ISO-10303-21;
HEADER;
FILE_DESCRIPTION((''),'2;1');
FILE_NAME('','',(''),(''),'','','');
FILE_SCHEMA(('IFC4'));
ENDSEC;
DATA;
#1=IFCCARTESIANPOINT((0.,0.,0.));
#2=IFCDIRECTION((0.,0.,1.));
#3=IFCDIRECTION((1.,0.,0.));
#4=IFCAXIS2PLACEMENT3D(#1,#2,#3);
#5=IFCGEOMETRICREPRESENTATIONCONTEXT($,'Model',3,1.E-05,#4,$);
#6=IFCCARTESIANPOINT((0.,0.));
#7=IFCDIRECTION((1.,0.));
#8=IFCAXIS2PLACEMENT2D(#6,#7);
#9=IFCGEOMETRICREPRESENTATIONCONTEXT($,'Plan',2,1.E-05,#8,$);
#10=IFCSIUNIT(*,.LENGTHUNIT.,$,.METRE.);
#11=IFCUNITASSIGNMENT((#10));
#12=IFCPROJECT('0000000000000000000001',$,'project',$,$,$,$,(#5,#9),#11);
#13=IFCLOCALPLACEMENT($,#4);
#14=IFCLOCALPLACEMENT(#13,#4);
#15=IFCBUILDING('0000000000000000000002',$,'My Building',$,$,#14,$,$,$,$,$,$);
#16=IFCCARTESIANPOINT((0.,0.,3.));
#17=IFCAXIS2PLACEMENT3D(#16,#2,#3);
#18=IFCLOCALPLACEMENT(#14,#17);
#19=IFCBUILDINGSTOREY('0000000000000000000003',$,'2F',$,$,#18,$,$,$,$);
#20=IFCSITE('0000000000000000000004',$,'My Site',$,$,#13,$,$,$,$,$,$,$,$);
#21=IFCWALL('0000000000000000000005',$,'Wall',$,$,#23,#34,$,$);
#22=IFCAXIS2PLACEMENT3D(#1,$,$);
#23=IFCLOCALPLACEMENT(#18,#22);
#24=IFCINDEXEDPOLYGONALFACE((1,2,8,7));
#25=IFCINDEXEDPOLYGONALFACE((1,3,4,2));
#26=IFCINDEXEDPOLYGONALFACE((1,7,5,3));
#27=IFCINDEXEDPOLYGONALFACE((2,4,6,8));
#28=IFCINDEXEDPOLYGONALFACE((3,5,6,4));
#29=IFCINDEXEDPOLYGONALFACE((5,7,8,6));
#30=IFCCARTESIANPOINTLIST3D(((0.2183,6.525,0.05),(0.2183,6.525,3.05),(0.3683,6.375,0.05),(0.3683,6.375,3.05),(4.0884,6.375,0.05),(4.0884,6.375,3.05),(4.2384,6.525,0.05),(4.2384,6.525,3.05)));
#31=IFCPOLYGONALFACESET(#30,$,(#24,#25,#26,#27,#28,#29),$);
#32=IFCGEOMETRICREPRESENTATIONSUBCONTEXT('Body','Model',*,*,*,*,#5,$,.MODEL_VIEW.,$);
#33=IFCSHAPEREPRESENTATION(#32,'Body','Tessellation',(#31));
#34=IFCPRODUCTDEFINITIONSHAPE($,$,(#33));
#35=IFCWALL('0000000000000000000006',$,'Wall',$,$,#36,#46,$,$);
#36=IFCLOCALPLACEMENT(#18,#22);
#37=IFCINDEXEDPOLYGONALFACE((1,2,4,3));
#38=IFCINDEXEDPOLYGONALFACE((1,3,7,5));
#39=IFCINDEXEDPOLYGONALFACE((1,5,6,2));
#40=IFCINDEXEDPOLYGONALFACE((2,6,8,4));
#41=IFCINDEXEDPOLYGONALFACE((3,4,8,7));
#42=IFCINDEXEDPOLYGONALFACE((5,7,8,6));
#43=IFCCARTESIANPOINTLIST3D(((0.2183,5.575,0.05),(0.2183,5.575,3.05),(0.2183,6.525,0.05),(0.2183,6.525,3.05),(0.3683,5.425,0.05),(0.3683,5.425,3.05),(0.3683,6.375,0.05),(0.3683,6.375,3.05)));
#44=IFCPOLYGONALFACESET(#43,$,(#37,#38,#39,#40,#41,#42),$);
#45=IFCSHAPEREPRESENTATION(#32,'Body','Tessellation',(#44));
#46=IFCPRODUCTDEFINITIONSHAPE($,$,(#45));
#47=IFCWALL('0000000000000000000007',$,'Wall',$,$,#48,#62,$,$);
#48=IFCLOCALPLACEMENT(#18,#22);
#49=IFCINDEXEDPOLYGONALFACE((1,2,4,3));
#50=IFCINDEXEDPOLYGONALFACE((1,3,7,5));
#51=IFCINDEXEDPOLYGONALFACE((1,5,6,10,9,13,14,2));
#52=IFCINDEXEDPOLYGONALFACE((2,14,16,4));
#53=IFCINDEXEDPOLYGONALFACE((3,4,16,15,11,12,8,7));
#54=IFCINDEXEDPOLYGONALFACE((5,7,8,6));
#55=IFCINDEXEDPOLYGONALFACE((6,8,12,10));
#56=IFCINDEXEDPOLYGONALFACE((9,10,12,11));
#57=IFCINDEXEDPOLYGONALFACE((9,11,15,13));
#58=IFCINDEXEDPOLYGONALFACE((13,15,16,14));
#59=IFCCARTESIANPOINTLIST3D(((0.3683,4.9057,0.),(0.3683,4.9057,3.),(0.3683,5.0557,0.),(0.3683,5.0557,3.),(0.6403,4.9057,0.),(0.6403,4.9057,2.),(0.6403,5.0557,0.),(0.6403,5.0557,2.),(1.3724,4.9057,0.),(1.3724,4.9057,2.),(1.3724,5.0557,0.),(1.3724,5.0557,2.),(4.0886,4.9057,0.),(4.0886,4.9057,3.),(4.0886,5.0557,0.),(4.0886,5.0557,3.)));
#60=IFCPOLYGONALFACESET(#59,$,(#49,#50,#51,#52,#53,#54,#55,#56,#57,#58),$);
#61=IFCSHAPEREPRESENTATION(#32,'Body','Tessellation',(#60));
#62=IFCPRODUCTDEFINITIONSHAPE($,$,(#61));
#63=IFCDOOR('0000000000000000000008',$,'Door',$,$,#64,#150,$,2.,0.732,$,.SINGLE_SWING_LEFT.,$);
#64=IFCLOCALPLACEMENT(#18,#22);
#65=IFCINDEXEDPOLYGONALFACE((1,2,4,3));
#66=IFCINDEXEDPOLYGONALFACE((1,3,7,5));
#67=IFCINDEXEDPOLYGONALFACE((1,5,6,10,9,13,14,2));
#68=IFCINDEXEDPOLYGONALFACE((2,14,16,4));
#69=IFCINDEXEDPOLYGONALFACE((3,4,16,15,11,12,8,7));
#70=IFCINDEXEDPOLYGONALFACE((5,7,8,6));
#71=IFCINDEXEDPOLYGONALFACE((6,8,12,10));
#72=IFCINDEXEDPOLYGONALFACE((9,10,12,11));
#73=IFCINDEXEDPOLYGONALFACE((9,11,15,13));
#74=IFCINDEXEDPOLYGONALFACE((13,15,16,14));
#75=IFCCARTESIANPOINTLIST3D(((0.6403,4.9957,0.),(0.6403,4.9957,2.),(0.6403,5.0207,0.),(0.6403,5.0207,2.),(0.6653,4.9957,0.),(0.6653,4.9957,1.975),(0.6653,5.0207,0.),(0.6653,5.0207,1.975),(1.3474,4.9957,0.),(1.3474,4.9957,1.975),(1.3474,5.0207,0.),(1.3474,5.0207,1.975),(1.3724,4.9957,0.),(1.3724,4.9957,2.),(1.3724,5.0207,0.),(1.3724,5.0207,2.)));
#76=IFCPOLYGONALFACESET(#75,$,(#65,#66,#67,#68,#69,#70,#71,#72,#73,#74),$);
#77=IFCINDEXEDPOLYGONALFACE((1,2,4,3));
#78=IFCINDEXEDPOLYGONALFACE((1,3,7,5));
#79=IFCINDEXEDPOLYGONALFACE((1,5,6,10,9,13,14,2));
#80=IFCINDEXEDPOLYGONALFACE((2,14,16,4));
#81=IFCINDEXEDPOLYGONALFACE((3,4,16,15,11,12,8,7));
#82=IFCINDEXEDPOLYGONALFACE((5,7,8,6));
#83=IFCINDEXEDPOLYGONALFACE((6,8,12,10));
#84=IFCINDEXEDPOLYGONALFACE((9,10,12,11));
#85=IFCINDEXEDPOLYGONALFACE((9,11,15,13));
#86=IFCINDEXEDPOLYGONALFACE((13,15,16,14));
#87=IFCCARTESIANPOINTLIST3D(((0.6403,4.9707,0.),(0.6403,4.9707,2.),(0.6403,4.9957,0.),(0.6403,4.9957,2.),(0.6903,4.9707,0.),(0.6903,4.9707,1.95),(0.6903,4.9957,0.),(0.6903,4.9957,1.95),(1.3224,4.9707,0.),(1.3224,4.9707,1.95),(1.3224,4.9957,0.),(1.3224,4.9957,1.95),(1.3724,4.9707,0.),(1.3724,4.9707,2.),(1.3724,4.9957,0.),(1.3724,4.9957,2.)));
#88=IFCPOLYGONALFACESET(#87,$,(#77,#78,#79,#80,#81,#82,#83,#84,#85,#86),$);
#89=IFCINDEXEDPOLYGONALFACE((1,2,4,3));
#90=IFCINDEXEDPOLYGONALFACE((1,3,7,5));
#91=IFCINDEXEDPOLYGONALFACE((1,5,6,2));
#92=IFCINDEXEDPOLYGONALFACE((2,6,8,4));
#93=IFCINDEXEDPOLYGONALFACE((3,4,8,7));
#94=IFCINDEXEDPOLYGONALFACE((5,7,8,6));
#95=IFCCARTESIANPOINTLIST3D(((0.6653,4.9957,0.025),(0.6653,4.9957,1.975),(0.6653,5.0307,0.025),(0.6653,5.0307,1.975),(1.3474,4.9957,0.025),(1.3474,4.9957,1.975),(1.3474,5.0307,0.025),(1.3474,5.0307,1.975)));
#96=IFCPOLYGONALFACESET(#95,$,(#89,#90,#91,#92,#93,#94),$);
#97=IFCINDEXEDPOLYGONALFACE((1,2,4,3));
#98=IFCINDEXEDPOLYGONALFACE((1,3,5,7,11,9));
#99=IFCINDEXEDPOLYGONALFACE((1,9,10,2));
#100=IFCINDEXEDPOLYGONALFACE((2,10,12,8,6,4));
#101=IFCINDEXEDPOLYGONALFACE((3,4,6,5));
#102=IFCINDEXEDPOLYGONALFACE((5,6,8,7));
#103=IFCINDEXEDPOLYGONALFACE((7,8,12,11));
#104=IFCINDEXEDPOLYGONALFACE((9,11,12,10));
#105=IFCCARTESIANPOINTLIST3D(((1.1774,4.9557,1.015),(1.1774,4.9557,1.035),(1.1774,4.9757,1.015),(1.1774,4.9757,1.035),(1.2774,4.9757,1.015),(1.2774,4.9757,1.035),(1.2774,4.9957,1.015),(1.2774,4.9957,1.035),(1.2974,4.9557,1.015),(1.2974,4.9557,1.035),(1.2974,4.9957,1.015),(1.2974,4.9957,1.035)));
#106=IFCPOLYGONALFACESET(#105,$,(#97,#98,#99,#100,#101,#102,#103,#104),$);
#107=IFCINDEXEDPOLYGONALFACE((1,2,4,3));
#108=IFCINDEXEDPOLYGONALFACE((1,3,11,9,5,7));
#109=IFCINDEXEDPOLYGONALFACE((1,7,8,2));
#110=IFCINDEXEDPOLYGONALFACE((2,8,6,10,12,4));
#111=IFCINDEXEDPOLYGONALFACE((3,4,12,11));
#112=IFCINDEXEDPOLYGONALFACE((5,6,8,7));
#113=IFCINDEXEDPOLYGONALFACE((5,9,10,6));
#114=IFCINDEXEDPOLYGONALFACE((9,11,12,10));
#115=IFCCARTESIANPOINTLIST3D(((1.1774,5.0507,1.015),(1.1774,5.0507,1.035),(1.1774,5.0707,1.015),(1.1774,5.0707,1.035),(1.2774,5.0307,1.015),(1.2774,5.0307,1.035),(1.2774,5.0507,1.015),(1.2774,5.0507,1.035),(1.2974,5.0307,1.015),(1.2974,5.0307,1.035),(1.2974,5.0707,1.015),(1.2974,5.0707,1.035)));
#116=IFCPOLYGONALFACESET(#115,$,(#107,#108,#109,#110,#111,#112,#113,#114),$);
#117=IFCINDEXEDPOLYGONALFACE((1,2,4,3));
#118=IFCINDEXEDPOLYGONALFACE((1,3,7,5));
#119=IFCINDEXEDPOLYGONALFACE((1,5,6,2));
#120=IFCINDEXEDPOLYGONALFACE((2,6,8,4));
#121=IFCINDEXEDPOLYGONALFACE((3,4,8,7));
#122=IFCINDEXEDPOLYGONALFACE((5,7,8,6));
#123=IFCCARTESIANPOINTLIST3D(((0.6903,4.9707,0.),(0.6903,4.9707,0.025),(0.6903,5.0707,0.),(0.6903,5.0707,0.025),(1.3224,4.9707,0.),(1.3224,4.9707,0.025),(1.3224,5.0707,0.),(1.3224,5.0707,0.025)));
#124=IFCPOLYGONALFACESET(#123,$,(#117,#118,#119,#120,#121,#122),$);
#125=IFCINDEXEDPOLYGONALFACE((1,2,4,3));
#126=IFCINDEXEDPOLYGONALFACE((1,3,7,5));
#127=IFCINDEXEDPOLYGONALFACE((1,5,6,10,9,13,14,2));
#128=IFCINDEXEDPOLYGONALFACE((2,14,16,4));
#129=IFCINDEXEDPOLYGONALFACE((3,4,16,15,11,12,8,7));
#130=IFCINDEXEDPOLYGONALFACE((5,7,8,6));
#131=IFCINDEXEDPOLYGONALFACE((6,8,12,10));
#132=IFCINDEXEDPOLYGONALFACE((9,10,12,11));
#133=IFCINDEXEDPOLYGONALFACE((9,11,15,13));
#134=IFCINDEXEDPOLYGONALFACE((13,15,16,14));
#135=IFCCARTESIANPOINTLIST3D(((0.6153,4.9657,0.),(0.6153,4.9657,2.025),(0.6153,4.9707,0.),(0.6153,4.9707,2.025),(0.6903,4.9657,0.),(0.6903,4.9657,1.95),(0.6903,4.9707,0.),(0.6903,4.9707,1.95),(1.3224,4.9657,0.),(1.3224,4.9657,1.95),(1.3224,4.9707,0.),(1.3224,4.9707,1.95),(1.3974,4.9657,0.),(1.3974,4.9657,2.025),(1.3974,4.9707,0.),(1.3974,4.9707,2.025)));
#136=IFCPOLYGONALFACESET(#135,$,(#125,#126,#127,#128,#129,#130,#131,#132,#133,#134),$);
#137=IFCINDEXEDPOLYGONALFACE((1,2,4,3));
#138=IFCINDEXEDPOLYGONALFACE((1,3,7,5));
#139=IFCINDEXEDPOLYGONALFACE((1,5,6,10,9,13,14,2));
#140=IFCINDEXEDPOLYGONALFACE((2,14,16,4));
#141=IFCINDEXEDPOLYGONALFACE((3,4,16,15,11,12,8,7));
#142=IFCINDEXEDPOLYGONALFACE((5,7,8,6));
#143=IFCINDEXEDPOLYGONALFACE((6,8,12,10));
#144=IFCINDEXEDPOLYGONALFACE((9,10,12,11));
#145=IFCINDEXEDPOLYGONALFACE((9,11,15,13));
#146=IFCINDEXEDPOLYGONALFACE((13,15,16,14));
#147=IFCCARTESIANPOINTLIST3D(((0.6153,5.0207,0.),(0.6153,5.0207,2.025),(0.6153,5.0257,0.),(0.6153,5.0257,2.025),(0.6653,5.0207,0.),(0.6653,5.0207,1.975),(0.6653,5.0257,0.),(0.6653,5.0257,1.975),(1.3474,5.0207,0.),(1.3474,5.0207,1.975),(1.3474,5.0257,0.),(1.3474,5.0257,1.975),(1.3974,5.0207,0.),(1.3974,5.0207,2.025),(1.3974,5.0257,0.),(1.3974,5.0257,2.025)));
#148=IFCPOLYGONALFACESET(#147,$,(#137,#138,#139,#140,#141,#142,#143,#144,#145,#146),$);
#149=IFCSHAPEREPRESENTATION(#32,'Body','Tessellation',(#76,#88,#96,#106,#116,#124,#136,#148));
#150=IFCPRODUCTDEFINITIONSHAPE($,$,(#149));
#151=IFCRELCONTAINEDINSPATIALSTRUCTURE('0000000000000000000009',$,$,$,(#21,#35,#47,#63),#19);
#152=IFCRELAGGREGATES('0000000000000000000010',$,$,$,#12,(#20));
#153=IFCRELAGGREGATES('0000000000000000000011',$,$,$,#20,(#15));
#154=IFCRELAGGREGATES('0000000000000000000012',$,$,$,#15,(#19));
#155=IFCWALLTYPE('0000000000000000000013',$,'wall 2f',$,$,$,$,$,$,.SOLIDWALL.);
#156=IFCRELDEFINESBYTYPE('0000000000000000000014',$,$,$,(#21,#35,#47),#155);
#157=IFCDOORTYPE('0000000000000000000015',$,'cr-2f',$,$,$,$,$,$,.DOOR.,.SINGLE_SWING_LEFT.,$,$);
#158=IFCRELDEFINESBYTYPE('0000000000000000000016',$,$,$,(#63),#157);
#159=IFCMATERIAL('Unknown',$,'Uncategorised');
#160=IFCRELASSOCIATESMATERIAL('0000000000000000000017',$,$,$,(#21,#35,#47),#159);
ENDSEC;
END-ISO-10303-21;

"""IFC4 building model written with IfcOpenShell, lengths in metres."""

from ifc_helpers import new_model, entity, si_unit, frame, origin_with_axes, origin_2d_with_axis, place, context, subcontext, project, spatial, line, indexed_curve, outline, extrude, shape, source, transform, mapped, material, type_object, type_shapes, element, fill, save


model = new_model("IFC4")

# Units and contexts
model_context = context("Model", 3, precision=1e-05, world=origin_with_axes())
plan_context = context("Plan", 2, precision=1e-05, world=origin_2d_with_axis())
body_context_1 = subcontext(model_context, "Body", "Model", "MODEL_VIEW")
body_context_2 = subcontext(plan_context, "Body", "Plan", "PLAN_VIEW")
ifc_project = project(units=[si_unit("LENGTHUNIT", "METRE")], contexts=[model_context, plan_context])

# Site, building, storey
site_placement = place(None, origin_with_axes())
site = spatial("IfcSite", under=ifc_project, at=site_placement, Name="My Site")
building_placement = place(site_placement, origin_with_axes())
building = spatial("IfcBuilding", under=site, at=building_placement, Name="My Building")
storey_placement = place(building_placement, frame((0.0, 0.0, 3.0), z_axis=(0.0, 0.0, 1.0), x_axis=(1.0, 0.0, 0.0)))
storey = spatial("IfcBuildingStorey", under=building, at=storey_placement, Name="2F")

# Shared definitions
ifc_material = material(Name="Unknown", Category="Uncategorised")

# Walls
wall_type_1 = type_object("IfcWallType", Name="wall 2f", PredefinedType="SOLIDWALL")
wall_1_placement = place(storey_placement, frame((4.2384, 6.525, 0.05), z_axis=(0.0, 0.0, 1.0), x_axis=(-1.0, 0.0, 0.0)))
element("IfcWall", 1, at=wall_1_placement, inside=storey, type_object=wall_type_1, material=ifc_material, Name="Wall", context=body_context_1, shape_type="SweptSolid", body=[
    extrude(outline(indexed_curve([(0.0, 0.0), (0.15, 0.15), (3.87, 0.15), (4.02, 0.0)], segments=[line(1, 2, 3, 4, 1)])), origin_with_axes(), (0.0, 0.0, 1.0), 3.0),
])
wall_2_placement = place(storey_placement, frame((0.2183, 6.525, 0.05), z_axis=(0.0, 0.0, 1.0), x_axis=(0.0, -1.0, 0.0)))
element("IfcWall", 2, at=wall_2_placement, inside=storey, type_object=wall_type_1, material=ifc_material, Name="Wall", context=body_context_1, shape_type="SweptSolid", body=[
    extrude(outline(indexed_curve([(0.0, 0.0), (0.15, 0.15), (1.1, 0.15), (0.95, 0.0)], segments=[line(1, 2, 3, 4, 1)])), origin_with_axes(), (0.0, 0.0, 1.0), 3.0),
])

# Wall, opening, door
wall_3_placement = place(storey_placement, frame((0.3683, 4.9057, 0.0), z_axis=(0.0, 0.0, 1.0), x_axis=(1.0, 0.0, 0.0)))
wall_3 = element("IfcWall", 3, at=wall_3_placement, inside=storey, type_object=wall_type_1, material=ifc_material, Name="Wall", context=body_context_1, shape_type="SweptSolid", body=[
    extrude(outline(indexed_curve([(0.0, 0.0), (0.0, 0.15), (3.7202, 0.15), (3.7202, 0.0)], segments=[line(1, 2, 3, 4, 1)])), origin_with_axes(), (0.0, 0.0, 1.0), 3.0),
])
shared_shape_1 = source(origin_with_axes(), body_context_1, "Body", "SweptSolid", [
    extrude(outline(indexed_curve([(0.0, 0.0), (0.732, 0.0), (0.732, 2.0), (0.0, 2.0)], segments=[line(1, 2, 3, 4, 1)])), frame((0.0, -0.6, 0.0), z_axis=(0.0, -1.0, 0.0), x_axis=(1.0, 0.0, 0.0)), (0.0, 0.0, -1.0), 1.2),
])
opening_1_placement = place(wall_3_placement, frame((0.272, 0.065, 0.0), z_axis=(0.0, 0.0, 1.0), x_axis=(1.0, 0.0, 0.0)))
opening_1 = element("IfcOpeningElement", 4, at=opening_1_placement, cuts=wall_3, PredefinedType="OPENING", context=body_context_1, shape_type="MappedRepresentation", body=[
    mapped(shared_shape_1, transform((0.0, 0.0, 0.0), x_axis=(1.0, 0.0, 0.0), y_axis=(0.0, 1.0, 0.0), z_axis=(0.0, 0.0, 1.0), scale=1.0)),
])
door_type_1 = type_object("IfcDoorType", Name="cr-2f", OperationType="SINGLE_SWING_LEFT", PredefinedType="DOOR")
shared_shape_2 = source(origin_with_axes(), body_context_1, "Body", "SweptSolid", [
    extrude(outline(indexed_curve([(0.0, 0.0), (0.0, 2.0), (0.732, 2.0), (0.732, 0.0), (0.707, 0.0), (0.707, 1.975), (0.025, 1.975), (0.025, 0.0)], segments=[line(1, 2, 3, 4, 5, 6, 7, 8, 1)])), frame((0.0, 0.025, 0.0), z_axis=(0.0, -1.0, 0.0), x_axis=(1.0, 0.0, 0.0)), (0.0, 0.0, -1.0), 0.025),
    extrude(outline(indexed_curve([(0.0, 0.0), (0.0, 2.0), (0.732, 2.0), (0.732, 0.0), (0.682, 0.0), (0.682, 1.95), (0.05, 1.95), (0.05, 0.0)], segments=[line(1, 2, 3, 4, 5, 6, 7, 8, 1)])), frame((0.0, 0.0, 0.0), z_axis=(0.0, -1.0, 0.0), x_axis=(1.0, 0.0, 0.0)), (0.0, 0.0, -1.0), 0.025),
    extrude(outline(indexed_curve([(0.0, 0.0), (0.682, 0.0), (0.682, 0.035), (0.0, 0.035)], segments=[line(1, 2, 3, 4, 1)])), frame((0.025, 0.025, 0.025), z_axis=(0.0, 0.0, 1.0), x_axis=(1.0, 0.0, 0.0)), (0.0, 0.0, 1.0), 1.95),
    extrude(outline(indexed_curve([(0.0, 0.0), (0.0, -0.04), (-0.12, -0.04), (-0.12, -0.02), (-0.02, -0.02), (-0.02, 0.0)], segments=[line(1, 2, 3, 4, 5, 6, 1)])), frame((0.657, 0.025, 1.015), z_axis=(0.0, 0.0, 1.0), x_axis=(1.0, 0.0, 0.0)), (0.0, 0.0, 1.0), 0.02),
    extrude(outline(indexed_curve([(0.0, 0.0), (0.0, 0.04), (-0.12, 0.04), (-0.12, 0.02), (-0.02, 0.02), (-0.02, 0.0)], segments=[line(1, 2, 3, 4, 5, 6, 1)])), frame((0.657, 0.06, 1.015), z_axis=(0.0, 0.0, 1.0), x_axis=(1.0, 0.0, 0.0)), (0.0, 0.0, 1.0), 0.02),
    extrude(outline(indexed_curve([(0.0, 0.0), (0.632, 0.0), (0.632, 0.1), (0.0, 0.1)], segments=[line(1, 2, 3, 4, 1)])), frame((0.05, 0.0, 0.0), z_axis=(0.0, 0.0, 1.0), x_axis=(1.0, 0.0, 0.0)), (0.0, 0.0, 1.0), 0.025),
    extrude(outline(indexed_curve([(0.0, 0.0), (0.0, 2.025), (0.782, 2.025), (0.782, 0.0), (0.707, 0.0), (0.707, 1.95), (0.075, 1.95), (0.075, 0.0)], segments=[line(1, 2, 3, 4, 5, 6, 7, 8, 1)])), frame((-0.025, -0.005, 0.0), z_axis=(0.0, -1.0, 0.0), x_axis=(1.0, 0.0, 0.0)), (0.0, 0.0, -1.0), 0.005),
    extrude(outline(indexed_curve([(0.0, 0.0), (0.0, 2.025), (0.782, 2.025), (0.782, 0.0), (0.732, 0.0), (0.732, 1.975), (0.05, 1.975), (0.05, 0.0)], segments=[line(1, 2, 3, 4, 5, 6, 7, 8, 1)])), frame((-0.025, 0.05, 0.0), z_axis=(0.0, -1.0, 0.0), x_axis=(1.0, 0.0, 0.0)), (0.0, 0.0, -1.0), 0.005),
])
shared_shape_3 = source(origin_with_axes(), body_context_2, "Body", "Curve2D", [
    entity("IfcIndexedPolyCurve", entity("IfcCartesianPointList2D", [[0.0, 0.0], [0.0, 0.05], [0.025, 0.05], [0.025, 0.025], [0.05, 0.025], [0.05, 0.0]]), [entity("IfcLineIndex", [1, 2, 3, 4, 5, 6, 1])]),
    entity("IfcIndexedPolyCurve", entity("IfcCartesianPointList2D", [[0.732, 0.0], [0.732, 0.05], [0.707, 0.05], [0.707, 0.025], [0.682, 0.025], [0.682, 0.0]]), [entity("IfcLineIndex", [1, 2, 3, 4, 5, 6, 1])]),
    entity("IfcTrimmedCurve", entity("IfcEllipse", entity("IfcAxis2Placement2D", entity("IfcCartesianPoint", [0.06, 0.05]), entity("IfcDirection", [1.0, 0.0])), 0.647, 0.682), [entity("IfcCartesianPoint", [0.707, 0.05])], [entity("IfcCartesianPoint", [0.06, 0.732])], True, "CARTESIAN"),
    entity("IfcIndexedPolyCurve", entity("IfcCartesianPointList2D", [[0.025, 0.05], [0.06, 0.05], [0.06, 0.732], [0.025, 0.732]]), [entity("IfcLineIndex", [1, 2, 3, 4, 1])]),
])
type_shapes(door_type_1, [shared_shape_2, shared_shape_3])
door_1_placement = place(opening_1_placement, frame((0.0, 0.0, 0.0), z_axis=(0.0, 0.0, 1.0), x_axis=(1.0, 0.0, 0.0)))
door_1 = element("IfcDoor", 5, at=door_1_placement, inside=storey, type_object=door_type_1, Name="Door", OperationType="SINGLE_SWING_LEFT", OverallHeight=2.0, OverallWidth=0.732, shapes=[
    shape(body_context_1, "Body", "MappedRepresentation", [mapped(shared_shape_2, transform((0.0, 0.0, 0.0), x_axis=(1.0, 0.0, 0.0), y_axis=(0.0, 1.0, 0.0), z_axis=(0.0, 0.0, 1.0), scale=1.0))]),
    shape(body_context_2, "Body", "MappedRepresentation", [mapped(shared_shape_3, transform((0.0, 0.0, 0.0), x_axis=(1.0, 0.0, 0.0), y_axis=(0.0, 1.0, 0.0), z_axis=(0.0, 0.0, 1.0), scale=1.0))]),
])
fill(opening_1, door_1)

save(model, "model.ifc")
